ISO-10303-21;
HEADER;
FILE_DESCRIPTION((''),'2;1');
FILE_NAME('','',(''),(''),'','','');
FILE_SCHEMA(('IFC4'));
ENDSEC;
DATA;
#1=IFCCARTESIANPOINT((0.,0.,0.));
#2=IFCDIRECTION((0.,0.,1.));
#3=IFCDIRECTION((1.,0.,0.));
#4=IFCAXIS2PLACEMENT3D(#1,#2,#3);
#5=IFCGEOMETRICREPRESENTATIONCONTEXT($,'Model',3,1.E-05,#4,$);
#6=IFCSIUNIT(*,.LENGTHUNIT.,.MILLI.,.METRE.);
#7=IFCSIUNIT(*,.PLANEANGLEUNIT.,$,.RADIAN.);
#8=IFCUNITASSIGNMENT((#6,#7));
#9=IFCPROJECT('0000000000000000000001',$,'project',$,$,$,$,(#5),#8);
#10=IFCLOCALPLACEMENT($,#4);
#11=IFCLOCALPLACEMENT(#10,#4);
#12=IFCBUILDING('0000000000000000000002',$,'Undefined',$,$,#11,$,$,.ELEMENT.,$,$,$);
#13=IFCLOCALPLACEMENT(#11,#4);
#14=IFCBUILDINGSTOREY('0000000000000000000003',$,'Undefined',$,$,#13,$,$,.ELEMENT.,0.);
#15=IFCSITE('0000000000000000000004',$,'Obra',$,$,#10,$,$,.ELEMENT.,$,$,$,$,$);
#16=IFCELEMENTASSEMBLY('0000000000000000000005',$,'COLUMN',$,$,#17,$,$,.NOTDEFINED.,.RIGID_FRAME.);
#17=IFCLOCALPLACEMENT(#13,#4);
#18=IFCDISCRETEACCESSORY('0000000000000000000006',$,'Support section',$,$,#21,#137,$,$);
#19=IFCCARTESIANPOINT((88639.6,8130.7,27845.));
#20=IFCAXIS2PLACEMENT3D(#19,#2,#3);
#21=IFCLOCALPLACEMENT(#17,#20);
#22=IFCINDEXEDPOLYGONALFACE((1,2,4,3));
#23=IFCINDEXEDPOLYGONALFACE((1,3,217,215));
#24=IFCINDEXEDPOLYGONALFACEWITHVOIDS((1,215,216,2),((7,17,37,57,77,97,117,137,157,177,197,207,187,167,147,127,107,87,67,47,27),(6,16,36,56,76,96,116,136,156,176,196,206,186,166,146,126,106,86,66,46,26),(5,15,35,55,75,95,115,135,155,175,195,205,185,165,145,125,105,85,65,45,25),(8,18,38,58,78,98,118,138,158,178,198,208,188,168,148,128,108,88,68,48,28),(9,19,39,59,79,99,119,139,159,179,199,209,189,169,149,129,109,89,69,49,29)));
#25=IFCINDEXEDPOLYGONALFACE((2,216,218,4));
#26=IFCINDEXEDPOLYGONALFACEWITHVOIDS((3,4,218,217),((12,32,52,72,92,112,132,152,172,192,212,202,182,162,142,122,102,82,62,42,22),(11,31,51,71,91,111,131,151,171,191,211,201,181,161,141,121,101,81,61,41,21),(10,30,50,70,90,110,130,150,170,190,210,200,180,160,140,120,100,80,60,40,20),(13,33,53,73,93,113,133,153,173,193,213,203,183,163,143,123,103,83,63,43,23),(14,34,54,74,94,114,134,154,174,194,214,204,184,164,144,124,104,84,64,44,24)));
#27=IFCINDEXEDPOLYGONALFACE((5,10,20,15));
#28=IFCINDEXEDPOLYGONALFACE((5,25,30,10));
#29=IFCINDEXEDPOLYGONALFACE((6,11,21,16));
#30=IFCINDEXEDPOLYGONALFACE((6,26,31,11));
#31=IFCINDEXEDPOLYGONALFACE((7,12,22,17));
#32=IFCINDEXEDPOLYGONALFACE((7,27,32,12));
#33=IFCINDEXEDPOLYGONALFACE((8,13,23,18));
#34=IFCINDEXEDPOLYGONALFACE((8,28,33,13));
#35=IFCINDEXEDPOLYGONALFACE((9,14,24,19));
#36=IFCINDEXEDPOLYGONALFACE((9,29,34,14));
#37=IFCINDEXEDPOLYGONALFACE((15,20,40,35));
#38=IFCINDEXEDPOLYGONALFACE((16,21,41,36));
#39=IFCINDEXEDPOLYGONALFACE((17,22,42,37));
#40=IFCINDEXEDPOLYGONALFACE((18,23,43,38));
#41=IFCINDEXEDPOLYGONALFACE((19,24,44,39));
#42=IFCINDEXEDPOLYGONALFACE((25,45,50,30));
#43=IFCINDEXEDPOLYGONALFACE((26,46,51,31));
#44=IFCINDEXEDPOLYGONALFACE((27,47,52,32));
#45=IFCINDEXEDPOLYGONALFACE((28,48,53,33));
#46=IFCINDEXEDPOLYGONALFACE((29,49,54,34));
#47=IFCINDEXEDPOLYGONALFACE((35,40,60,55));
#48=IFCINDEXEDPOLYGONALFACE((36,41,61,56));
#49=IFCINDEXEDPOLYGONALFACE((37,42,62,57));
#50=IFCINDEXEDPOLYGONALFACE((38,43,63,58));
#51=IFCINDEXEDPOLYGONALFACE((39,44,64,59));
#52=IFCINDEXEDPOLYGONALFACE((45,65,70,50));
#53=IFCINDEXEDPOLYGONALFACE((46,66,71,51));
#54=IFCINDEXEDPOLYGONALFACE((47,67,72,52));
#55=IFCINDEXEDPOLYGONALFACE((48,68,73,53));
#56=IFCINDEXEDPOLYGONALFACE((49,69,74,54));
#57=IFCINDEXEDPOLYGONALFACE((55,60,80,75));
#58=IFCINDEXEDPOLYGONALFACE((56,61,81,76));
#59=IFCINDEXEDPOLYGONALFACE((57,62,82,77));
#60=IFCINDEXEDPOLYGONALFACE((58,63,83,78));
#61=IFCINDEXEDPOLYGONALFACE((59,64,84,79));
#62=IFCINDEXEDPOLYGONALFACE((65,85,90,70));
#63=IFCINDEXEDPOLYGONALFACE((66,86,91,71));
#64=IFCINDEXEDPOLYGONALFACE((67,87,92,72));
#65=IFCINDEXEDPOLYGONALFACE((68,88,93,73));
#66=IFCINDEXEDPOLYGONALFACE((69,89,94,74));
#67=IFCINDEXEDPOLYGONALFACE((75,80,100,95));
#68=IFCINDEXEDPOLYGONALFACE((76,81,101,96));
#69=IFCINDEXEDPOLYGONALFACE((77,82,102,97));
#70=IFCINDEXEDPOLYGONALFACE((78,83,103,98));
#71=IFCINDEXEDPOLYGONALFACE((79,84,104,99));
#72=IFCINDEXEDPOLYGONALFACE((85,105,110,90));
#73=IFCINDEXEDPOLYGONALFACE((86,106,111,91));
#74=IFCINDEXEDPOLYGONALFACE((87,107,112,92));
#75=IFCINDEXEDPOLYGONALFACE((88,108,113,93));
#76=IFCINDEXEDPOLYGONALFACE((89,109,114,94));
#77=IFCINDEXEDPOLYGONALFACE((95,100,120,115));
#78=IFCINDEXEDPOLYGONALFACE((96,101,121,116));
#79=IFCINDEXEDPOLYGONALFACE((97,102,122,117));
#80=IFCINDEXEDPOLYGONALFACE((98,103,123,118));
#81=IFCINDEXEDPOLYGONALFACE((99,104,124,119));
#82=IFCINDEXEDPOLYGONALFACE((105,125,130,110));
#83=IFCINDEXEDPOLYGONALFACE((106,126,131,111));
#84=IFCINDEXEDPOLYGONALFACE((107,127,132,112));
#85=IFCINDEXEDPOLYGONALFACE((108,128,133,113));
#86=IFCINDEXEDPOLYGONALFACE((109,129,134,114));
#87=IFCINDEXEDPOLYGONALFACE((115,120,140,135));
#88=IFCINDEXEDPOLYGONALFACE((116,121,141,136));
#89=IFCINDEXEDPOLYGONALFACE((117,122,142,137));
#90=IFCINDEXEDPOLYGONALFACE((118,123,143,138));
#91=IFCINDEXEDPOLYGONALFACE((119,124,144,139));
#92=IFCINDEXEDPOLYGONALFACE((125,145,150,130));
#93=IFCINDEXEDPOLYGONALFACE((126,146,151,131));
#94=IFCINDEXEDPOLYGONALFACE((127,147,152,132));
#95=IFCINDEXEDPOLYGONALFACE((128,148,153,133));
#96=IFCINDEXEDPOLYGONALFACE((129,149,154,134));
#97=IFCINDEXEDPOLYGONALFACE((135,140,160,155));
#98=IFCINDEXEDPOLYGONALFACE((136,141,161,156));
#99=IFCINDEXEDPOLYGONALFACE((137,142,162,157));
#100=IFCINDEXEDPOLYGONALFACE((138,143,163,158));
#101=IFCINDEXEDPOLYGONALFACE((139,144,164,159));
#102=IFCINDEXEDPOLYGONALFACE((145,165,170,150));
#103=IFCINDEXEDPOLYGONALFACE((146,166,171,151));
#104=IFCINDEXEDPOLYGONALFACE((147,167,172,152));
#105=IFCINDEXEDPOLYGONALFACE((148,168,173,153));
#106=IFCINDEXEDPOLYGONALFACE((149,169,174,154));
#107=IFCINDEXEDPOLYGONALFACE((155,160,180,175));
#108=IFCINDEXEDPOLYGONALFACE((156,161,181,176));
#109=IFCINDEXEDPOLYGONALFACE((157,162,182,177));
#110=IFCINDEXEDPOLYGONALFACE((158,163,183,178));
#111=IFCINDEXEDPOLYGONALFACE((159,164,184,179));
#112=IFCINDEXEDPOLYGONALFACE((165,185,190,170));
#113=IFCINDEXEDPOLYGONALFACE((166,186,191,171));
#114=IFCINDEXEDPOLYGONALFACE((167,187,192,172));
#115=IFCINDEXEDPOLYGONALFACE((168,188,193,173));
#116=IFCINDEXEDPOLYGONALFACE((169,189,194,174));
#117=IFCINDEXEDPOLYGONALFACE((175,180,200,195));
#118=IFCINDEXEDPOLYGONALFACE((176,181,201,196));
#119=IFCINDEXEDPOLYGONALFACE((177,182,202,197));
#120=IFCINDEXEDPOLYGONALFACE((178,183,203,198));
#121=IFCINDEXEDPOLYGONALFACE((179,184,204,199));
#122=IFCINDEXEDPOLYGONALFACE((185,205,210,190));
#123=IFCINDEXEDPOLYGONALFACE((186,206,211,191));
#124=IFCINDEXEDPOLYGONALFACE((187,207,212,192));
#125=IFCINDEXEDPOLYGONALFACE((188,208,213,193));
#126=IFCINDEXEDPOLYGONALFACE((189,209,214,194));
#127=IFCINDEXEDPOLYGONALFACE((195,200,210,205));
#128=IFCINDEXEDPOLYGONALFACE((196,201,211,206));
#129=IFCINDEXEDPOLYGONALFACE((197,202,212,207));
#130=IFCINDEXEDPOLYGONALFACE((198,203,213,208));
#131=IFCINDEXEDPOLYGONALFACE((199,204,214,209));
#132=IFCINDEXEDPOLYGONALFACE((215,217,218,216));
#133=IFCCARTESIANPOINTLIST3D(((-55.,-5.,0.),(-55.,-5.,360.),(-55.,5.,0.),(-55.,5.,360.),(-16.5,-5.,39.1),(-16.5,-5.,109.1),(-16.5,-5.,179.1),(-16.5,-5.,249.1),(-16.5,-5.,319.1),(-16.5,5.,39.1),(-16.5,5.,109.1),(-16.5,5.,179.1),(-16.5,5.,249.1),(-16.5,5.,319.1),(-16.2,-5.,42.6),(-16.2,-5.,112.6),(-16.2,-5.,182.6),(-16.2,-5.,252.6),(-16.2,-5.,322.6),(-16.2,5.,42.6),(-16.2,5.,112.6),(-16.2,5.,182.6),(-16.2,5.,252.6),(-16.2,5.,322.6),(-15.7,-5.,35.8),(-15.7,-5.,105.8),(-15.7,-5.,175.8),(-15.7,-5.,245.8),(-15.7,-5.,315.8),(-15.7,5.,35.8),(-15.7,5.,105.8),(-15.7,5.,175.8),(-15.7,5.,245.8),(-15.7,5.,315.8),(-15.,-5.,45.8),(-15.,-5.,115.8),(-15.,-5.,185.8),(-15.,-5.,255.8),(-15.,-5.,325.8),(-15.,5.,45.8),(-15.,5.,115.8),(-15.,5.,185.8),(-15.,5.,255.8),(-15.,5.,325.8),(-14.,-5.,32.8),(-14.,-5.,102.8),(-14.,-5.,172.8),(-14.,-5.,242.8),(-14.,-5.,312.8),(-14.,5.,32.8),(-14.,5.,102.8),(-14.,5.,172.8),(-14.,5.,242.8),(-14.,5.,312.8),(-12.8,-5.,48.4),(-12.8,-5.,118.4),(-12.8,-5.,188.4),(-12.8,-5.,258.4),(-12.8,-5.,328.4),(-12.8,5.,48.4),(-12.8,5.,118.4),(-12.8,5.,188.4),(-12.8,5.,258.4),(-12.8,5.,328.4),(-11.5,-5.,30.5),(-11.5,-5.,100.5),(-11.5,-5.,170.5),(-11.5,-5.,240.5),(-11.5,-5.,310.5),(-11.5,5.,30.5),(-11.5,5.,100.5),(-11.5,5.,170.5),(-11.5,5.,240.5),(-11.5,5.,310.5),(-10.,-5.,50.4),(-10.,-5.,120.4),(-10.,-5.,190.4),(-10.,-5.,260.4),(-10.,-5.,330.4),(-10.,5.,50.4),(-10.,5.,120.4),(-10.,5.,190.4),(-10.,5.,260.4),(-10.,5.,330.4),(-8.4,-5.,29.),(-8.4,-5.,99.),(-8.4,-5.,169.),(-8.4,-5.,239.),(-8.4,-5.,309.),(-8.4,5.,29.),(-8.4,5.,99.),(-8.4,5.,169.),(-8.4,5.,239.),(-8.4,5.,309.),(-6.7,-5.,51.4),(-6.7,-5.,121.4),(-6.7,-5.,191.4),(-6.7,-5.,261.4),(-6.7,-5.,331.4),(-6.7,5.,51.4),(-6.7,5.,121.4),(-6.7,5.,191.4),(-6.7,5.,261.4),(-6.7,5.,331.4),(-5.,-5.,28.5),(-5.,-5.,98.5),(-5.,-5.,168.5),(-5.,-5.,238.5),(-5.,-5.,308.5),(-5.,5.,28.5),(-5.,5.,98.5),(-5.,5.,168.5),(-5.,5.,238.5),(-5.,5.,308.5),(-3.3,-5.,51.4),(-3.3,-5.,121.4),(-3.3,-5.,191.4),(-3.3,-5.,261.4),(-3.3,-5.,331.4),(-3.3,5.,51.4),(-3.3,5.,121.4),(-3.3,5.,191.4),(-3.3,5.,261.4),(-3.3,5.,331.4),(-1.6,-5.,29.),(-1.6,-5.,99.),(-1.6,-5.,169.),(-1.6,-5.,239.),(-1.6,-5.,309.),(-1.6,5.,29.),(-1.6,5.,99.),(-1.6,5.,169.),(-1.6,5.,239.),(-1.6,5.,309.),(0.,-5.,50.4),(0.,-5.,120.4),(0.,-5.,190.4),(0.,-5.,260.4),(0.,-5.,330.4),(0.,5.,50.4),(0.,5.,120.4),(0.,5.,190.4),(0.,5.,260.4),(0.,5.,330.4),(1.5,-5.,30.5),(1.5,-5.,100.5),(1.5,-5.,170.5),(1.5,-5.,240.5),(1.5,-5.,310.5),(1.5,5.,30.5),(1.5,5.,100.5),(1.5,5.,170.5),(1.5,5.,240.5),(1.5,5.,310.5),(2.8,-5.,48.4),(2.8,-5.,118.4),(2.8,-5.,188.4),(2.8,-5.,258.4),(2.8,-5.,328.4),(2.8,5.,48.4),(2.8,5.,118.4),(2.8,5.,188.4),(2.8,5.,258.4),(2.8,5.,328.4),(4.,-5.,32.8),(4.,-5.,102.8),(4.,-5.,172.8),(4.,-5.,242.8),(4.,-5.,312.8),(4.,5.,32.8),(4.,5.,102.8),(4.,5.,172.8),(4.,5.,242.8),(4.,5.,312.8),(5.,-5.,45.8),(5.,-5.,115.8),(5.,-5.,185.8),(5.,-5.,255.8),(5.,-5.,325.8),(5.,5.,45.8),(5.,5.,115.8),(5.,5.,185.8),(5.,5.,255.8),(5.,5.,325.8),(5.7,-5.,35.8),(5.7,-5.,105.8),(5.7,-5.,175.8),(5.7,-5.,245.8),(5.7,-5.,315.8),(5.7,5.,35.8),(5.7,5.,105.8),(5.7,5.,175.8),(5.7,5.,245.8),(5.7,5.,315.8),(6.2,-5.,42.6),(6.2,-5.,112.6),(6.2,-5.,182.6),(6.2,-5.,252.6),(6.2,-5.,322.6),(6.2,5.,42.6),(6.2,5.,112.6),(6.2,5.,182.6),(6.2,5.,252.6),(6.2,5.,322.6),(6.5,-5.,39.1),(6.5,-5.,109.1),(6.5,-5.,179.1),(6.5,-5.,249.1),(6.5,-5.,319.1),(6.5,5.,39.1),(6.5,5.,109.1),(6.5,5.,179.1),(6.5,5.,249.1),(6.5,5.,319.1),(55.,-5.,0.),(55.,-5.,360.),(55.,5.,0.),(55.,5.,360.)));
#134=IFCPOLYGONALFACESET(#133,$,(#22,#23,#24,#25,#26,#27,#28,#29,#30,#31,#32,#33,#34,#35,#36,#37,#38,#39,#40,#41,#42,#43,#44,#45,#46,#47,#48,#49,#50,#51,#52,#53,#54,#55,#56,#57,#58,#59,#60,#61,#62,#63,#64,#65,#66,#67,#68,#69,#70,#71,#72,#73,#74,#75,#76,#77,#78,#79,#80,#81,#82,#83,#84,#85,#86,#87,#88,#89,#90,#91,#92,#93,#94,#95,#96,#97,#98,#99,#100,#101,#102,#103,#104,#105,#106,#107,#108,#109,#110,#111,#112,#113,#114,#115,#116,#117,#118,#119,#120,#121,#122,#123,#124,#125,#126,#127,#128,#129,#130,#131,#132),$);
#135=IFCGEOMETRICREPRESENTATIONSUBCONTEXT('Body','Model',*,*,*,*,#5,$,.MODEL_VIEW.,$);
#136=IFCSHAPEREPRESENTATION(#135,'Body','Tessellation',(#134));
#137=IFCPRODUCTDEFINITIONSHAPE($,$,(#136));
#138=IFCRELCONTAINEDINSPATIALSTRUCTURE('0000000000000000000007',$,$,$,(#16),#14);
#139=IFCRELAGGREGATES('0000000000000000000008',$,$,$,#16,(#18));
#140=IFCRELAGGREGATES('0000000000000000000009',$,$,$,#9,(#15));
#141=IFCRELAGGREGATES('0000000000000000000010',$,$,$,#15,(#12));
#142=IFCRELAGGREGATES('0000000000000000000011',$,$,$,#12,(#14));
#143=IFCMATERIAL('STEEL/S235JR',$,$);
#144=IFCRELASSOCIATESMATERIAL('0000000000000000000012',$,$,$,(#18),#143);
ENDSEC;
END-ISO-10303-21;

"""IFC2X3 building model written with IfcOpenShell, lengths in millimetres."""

from ifc_helpers import new_model, si_unit, frame, origin_with_axes, origin_2d_with_axis, place, context, subcontext, project, spatial, rectangle, circle, extrude, source, transform, mapped, material, element, aggregate, save


model = new_model("IFC2X3")

# Units and contexts
model_context = context("Model", 3, precision=1e-05, world=origin_with_axes())
body_context = subcontext(model_context, "Body", "Model", "MODEL_VIEW")
ifc_project = project(units=[si_unit("LENGTHUNIT", "METRE", prefix="MILLI"), si_unit("PLANEANGLEUNIT", "RADIAN")], contexts=[model_context])

# Site, building, storey
site_placement = place(None, origin_with_axes())
site = spatial("IfcSite", under=ifc_project, at=site_placement, Name="Obra", CompositionType="ELEMENT")
building_placement = place(site_placement, origin_with_axes())
building = spatial("IfcBuilding", under=site, at=building_placement, Name="Undefined", CompositionType="ELEMENT")
storey_placement = place(building_placement, origin_with_axes())
storey = spatial("IfcBuildingStorey", under=building, at=storey_placement, Name="Undefined", CompositionType="ELEMENT", Elevation=0.0)

# Element assembly
ifc_material_1 = material(Name="STEEL/S235JR")
assembly_1_placement = place(storey_placement, origin_with_axes())
assembly_1 = element("IfcElementAssembly", 1, at=assembly_1_placement, inside=storey, Name="COLUMN", AssemblyPlace="NOTDEFINED", PredefinedType="RIGID_FRAME")

# Discrete accessory, opening
shared_shape_1 = source(origin_with_axes(), body_context, "Body", "SweptSolid", [
    extrude(circle(Radius=11.5, at=origin_2d_with_axis()), frame((0.0, -15.7, 0.0), z_axis=(0.0, 1.0, 0.0), x_axis=(1.0, 0.0, 0.0)), (0.0, 0.0, 1.0), 10.2),
])
discrete_accessory_1_placement = place(assembly_1_placement, frame((88639.6, 8130.7, 27845.0), z_axis=(0.0, 0.0, 1.0), x_axis=(1.0, 0.0, 0.0)))
discrete_accessory_1 = element("IfcDiscreteAccessory", 2, at=discrete_accessory_1_placement, material=ifc_material_1, Name="Support section", context=body_context, shape_type="SweptSolid", body=[
    extrude(rectangle(XDim=10.0, YDim=110.0, at=origin_2d_with_axis()), frame((0.0, 0.0, 360.0), z_axis=(0.0, 0.0, -1.0), x_axis=(0.0, 1.0, 0.0)), (0.0, 0.0, 1.0), 360.0),
])
opening_1_placement = place(assembly_1_placement, frame((88684.6, 8120.2, 28300.0), z_axis=(-1.0, 0.0, 0.0), x_axis=(0.0, 0.0, -1.0)))
element("IfcOpeningElement", 3, at=opening_1_placement, cuts=discrete_accessory_1, ObjectType="Opening", context=body_context, shape_type="MappedRepresentation", body=[
    mapped(shared_shape_1, transform((135.0, 0.0, 50.0))),
    mapped(shared_shape_1, transform((205.0, 0.0, 50.0))),
    mapped(shared_shape_1, transform((275.0, 0.0, 50.0))),
    mapped(shared_shape_1, transform((345.0, 0.0, 50.0))),
    mapped(shared_shape_1, transform((415.0, 0.0, 50.0))),
])
aggregate(assembly_1, [discrete_accessory_1])

save(model, "model.ifc")
